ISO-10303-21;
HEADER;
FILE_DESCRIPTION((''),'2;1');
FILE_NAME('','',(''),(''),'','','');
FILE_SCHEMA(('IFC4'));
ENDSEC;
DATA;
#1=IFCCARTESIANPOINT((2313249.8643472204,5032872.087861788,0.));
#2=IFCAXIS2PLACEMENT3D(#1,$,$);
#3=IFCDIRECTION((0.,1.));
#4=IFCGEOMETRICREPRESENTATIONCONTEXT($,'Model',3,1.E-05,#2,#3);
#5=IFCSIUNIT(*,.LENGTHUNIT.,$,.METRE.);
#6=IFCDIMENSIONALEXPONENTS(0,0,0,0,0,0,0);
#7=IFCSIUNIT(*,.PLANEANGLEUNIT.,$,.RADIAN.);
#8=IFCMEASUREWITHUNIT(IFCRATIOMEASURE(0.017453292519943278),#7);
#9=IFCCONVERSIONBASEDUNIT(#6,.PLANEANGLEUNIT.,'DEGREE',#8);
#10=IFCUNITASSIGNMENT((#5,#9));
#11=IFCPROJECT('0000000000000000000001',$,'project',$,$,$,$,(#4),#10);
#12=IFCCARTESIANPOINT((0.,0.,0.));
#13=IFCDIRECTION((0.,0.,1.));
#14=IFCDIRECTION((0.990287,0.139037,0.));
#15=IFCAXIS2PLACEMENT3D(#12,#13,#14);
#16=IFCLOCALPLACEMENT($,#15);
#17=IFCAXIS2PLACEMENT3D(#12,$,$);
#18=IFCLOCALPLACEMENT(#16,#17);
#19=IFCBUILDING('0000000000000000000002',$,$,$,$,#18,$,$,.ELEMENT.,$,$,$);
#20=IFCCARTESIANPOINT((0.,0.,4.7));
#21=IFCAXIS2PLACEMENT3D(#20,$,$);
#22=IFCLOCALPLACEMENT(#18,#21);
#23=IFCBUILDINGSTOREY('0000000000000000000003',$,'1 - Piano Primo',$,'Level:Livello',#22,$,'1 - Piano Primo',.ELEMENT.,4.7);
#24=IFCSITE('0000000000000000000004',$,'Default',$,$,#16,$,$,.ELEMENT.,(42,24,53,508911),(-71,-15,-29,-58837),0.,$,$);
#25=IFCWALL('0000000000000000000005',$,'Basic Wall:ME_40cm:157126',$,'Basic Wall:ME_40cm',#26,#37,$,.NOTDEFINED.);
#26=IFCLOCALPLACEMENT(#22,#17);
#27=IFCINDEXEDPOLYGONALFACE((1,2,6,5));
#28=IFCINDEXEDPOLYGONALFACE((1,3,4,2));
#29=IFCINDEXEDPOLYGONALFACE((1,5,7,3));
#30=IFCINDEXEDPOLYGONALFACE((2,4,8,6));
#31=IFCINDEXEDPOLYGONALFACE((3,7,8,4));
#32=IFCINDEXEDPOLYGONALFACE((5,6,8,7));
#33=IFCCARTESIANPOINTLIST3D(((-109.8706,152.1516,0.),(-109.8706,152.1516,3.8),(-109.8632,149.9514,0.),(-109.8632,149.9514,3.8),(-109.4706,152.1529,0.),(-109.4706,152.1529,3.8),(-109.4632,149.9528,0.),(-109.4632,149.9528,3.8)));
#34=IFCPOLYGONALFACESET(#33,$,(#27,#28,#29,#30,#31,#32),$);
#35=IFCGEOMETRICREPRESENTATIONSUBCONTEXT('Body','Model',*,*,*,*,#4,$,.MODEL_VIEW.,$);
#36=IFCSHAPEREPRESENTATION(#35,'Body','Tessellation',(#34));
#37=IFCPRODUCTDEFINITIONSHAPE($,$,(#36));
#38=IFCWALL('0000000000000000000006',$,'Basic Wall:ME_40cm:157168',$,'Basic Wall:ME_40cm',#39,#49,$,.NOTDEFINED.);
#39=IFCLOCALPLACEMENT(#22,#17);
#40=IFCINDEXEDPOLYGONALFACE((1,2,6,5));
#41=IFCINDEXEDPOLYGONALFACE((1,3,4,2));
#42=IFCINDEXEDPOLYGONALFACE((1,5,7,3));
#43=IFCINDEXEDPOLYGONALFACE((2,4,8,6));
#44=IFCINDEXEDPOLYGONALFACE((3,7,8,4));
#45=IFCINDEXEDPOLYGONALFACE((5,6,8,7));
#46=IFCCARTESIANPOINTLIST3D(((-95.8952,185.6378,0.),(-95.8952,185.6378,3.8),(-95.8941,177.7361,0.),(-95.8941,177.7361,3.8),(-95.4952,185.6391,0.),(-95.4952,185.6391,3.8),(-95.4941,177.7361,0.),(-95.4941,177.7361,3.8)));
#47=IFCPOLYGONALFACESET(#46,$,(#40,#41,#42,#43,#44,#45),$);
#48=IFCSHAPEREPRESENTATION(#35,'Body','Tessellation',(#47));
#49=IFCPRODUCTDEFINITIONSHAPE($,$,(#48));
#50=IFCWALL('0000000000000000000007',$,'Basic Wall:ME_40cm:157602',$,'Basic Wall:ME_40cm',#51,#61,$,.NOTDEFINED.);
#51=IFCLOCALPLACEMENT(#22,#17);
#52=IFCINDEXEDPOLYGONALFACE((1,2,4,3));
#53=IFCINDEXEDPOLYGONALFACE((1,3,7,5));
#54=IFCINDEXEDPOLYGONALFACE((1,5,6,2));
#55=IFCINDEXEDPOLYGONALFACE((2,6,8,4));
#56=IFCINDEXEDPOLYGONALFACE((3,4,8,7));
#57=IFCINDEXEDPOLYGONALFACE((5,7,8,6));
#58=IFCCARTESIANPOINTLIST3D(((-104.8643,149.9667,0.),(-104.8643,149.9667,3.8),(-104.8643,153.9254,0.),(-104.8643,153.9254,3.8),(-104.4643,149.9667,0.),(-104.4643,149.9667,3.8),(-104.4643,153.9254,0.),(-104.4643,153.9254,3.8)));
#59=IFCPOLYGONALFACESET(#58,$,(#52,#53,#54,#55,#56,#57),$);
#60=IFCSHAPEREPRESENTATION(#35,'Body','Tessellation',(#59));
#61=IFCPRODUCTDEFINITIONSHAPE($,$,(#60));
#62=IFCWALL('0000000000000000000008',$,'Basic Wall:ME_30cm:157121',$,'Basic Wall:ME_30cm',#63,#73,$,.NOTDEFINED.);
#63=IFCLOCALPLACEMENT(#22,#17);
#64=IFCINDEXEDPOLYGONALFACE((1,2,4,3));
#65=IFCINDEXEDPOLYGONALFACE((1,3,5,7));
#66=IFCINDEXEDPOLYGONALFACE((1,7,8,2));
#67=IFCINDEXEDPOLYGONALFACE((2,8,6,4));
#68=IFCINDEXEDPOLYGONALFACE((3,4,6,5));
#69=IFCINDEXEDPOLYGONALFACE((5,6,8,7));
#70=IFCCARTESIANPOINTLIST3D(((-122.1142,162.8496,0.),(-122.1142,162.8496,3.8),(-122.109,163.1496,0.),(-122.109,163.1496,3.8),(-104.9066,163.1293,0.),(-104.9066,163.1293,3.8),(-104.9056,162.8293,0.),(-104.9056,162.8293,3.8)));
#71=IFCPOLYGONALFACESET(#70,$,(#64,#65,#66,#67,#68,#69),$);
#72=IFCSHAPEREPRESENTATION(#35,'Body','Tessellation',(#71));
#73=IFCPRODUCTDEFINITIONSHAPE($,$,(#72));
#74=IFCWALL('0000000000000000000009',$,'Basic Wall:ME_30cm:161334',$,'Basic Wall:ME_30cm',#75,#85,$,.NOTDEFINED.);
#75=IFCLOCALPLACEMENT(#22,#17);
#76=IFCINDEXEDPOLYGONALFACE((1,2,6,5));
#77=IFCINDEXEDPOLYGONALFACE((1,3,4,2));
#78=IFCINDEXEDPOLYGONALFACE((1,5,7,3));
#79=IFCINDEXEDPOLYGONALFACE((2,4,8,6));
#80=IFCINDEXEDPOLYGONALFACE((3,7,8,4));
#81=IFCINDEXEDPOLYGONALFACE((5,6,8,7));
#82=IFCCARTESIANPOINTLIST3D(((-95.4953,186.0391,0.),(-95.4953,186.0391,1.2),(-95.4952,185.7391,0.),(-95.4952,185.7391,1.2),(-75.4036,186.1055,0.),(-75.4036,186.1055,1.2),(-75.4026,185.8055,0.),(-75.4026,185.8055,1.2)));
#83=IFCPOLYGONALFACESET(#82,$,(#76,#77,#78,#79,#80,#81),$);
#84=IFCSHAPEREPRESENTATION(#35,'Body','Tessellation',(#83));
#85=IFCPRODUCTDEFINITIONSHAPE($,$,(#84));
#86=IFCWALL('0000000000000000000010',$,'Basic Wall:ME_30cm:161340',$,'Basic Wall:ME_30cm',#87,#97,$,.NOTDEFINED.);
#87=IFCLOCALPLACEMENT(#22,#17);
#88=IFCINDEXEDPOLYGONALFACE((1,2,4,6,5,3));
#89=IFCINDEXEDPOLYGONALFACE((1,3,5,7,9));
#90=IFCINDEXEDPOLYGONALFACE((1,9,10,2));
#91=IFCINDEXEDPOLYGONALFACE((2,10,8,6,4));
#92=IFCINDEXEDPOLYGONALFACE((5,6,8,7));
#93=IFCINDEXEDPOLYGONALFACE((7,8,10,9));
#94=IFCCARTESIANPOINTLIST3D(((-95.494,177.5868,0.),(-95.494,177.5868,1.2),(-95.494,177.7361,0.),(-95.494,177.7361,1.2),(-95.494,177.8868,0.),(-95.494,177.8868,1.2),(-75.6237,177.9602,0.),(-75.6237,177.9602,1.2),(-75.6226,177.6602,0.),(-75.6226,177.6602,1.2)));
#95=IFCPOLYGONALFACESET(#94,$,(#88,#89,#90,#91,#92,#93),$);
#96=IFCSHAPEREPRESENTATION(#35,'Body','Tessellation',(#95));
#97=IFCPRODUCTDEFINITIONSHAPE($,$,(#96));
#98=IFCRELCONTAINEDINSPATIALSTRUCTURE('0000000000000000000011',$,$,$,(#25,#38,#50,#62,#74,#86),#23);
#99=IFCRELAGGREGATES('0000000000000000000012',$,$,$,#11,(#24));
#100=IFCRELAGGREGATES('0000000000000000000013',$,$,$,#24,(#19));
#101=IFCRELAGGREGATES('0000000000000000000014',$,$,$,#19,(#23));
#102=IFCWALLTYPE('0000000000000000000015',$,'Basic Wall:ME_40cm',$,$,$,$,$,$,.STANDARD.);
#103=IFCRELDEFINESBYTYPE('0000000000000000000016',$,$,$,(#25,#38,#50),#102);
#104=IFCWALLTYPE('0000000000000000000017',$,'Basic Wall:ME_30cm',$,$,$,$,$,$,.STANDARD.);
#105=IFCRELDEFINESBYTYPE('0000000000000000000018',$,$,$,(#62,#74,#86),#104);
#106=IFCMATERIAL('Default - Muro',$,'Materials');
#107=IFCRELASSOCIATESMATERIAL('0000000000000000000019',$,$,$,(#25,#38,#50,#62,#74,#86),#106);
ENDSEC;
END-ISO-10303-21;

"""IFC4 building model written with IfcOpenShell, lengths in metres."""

from ifc_helpers import new_model, entity, si_unit, converted_unit, direction, frame, origin, place, context, subcontext, project, spatial, indexed_curve, outline, extrude, material, type_object, element, save


model = new_model("IFC4")

# Units and contexts
model_context = context("Model", 3, precision=1e-05, world=frame((2313249.8643472204, 5032872.087861788, 0.0)), true_north=direction((0.0, 1.0)))
body_context = subcontext(model_context, "Body", "Model", "MODEL_VIEW")
ifc_project = project(units=[si_unit("LENGTHUNIT", "METRE"), converted_unit("PLANEANGLEUNIT", "DEGREE", entity("IfcRatioMeasure", 0.017453292519943278), si_unit("PLANEANGLEUNIT", "RADIAN"), dimensions=[0, 0, 0, 0, 0, 0, 0])], contexts=[model_context])

# Site, building, storey
site_placement = place(None, frame((0.0, 0.0, 0.0), z_axis=(0.0, 0.0, 1.0), x_axis=(0.990287, 0.139037, 0.0)))
site = spatial("IfcSite", under=ifc_project, at=site_placement, Name="Default", CompositionType="ELEMENT", RefLatitude=(42, 24, 53, 508911), RefLongitude=(-71, -15, -29, -58837), RefElevation=0.0)
building_placement = place(site_placement, origin())
building = spatial("IfcBuilding", under=site, at=building_placement, CompositionType="ELEMENT")
storey_placement = place(building_placement, frame((0.0, 0.0, 4.7)))
storey = spatial("IfcBuildingStorey", under=building, at=storey_placement, Name="1 - Piano Primo", ObjectType="Level:Livello", LongName="1 - Piano Primo", CompositionType="ELEMENT", Elevation=4.7)

# Walls
ifc_material_1 = material(Name="Default - Muro", Category="Materials")
wall_type_1 = type_object("IfcWallType", Name="Basic Wall:ME_40cm", PredefinedType="STANDARD")
wall_1_placement = place(storey_placement, frame((-109.6632, 149.9521, 0.0), z_axis=(0.0, 0.0, 1.0), x_axis=(-0.003356, 0.999994, 0.0)))
element("IfcWall", 1, at=wall_1_placement, inside=storey, type_object=wall_type_1, material=ifc_material_1, Name="Basic Wall:ME_40cm:157126", ObjectType="Basic Wall:ME_40cm", PredefinedType="NOTDEFINED", context=body_context, shape_type="SweptSolid", body=[
    extrude(outline(indexed_curve([(2.2002, 0.2), (0.0, 0.2), (0.0, -0.2), (2.2002, -0.2), (2.2002, 0.2)], self_intersect=False)), origin(), (0.0, 0.0, 1.0), 3.8),
])
wall_2_placement = place(storey_placement, frame((-95.6952, 185.6391, 0.0), z_axis=(0.0, 0.0, 1.0), x_axis=(0.000147, -1.0, 0.0)))
element("IfcWall", 2, at=wall_2_placement, inside=storey, type_object=wall_type_1, material=ifc_material_1, Name="Basic Wall:ME_40cm:157168", ObjectType="Basic Wall:ME_40cm", PredefinedType="NOTDEFINED", context=body_context, shape_type="SweptSolid", body=[
    extrude(outline(indexed_curve([(7.903, -0.2), (7.903, 0.2), (0.0, 0.2), (0.0013, -0.2), (7.903, -0.2)], self_intersect=False)), origin(), (0.0, 0.0, 1.0), 3.8),
])
wall_3_placement = place(storey_placement, frame((-104.6643, 149.9667, 0.0), z_axis=(0.0, 0.0, 1.0), x_axis=(0.0, 1.0, 0.0)))
element("IfcWall", 3, at=wall_3_placement, inside=storey, type_object=wall_type_1, material=ifc_material_1, Name="Basic Wall:ME_40cm:157602", ObjectType="Basic Wall:ME_40cm", PredefinedType="NOTDEFINED", context=body_context, shape_type="SweptSolid", body=[
    extrude(outline(indexed_curve([(3.9587, 0.2), (0.0, 0.2), (0.0, -0.2), (3.9587, -0.2), (3.9587, 0.2)], self_intersect=False)), origin(), (0.0, 0.0, 1.0), 3.8),
])
wall_type_2 = type_object("IfcWallType", Name="Basic Wall:ME_30cm", PredefinedType="STANDARD")
wall_4_placement = place(storey_placement, frame((-122.114, 162.9996, 0.0), z_axis=(0.0, 0.0, 1.0), x_axis=(0.999999, -0.001178, 0.0)))
element("IfcWall", 4, at=wall_4_placement, inside=storey, type_object=wall_type_2, material=ifc_material_1, Name="Basic Wall:ME_30cm:157121", ObjectType="Basic Wall:ME_30cm", PredefinedType="NOTDEFINED", context=body_context, shape_type="SweptSolid", body=[
    extrude(outline(indexed_curve([(17.2086, -0.15), (17.2073, 0.15), (0.0049, 0.15), (0.0, -0.15), (17.2086, -0.15)], self_intersect=False)), origin(), (0.0, 0.0, 1.0), 3.8),
])
wall_5_placement = place(storey_placement, frame((-95.4957, 185.8891, 0.0), z_axis=(0.0, 0.0, 1.0), x_axis=(0.999995, 0.003303, 0.0)))
element("IfcWall", 5, at=wall_5_placement, inside=storey, type_object=wall_type_2, material=ifc_material_1, Name="Basic Wall:ME_30cm:161334", ObjectType="Basic Wall:ME_30cm", PredefinedType="NOTDEFINED", context=body_context, shape_type="SweptSolid", body=[
    extrude(outline(indexed_curve([(20.0927, -0.15), (20.0927, 0.15), (0.0009, 0.15), (0.0, -0.15), (20.0927, -0.15)], self_intersect=False)), origin(), (0.0, 0.0, 1.0), 1.2),
])
wall_6_placement = place(storey_placement, frame((-75.6231, 177.8102, 0.0), z_axis=(0.0, 0.0, 1.0), x_axis=(-0.999993, -0.003692, 0.0)))
element("IfcWall", 6, at=wall_6_placement, inside=storey, type_object=wall_type_2, material=ifc_material_1, Name="Basic Wall:ME_30cm:161340", ObjectType="Basic Wall:ME_30cm", PredefinedType="NOTDEFINED", context=body_context, shape_type="SweptSolid", body=[
    extrude(outline(indexed_curve([(19.8704, -0.15), (19.871, 0.0007), (19.8716, 0.15), (0.0, 0.15), (0.0, -0.15), (19.8704, -0.15)], self_intersect=False)), origin(), (0.0, 0.0, 1.0), 1.2),
])

save(model, "model.ifc")
